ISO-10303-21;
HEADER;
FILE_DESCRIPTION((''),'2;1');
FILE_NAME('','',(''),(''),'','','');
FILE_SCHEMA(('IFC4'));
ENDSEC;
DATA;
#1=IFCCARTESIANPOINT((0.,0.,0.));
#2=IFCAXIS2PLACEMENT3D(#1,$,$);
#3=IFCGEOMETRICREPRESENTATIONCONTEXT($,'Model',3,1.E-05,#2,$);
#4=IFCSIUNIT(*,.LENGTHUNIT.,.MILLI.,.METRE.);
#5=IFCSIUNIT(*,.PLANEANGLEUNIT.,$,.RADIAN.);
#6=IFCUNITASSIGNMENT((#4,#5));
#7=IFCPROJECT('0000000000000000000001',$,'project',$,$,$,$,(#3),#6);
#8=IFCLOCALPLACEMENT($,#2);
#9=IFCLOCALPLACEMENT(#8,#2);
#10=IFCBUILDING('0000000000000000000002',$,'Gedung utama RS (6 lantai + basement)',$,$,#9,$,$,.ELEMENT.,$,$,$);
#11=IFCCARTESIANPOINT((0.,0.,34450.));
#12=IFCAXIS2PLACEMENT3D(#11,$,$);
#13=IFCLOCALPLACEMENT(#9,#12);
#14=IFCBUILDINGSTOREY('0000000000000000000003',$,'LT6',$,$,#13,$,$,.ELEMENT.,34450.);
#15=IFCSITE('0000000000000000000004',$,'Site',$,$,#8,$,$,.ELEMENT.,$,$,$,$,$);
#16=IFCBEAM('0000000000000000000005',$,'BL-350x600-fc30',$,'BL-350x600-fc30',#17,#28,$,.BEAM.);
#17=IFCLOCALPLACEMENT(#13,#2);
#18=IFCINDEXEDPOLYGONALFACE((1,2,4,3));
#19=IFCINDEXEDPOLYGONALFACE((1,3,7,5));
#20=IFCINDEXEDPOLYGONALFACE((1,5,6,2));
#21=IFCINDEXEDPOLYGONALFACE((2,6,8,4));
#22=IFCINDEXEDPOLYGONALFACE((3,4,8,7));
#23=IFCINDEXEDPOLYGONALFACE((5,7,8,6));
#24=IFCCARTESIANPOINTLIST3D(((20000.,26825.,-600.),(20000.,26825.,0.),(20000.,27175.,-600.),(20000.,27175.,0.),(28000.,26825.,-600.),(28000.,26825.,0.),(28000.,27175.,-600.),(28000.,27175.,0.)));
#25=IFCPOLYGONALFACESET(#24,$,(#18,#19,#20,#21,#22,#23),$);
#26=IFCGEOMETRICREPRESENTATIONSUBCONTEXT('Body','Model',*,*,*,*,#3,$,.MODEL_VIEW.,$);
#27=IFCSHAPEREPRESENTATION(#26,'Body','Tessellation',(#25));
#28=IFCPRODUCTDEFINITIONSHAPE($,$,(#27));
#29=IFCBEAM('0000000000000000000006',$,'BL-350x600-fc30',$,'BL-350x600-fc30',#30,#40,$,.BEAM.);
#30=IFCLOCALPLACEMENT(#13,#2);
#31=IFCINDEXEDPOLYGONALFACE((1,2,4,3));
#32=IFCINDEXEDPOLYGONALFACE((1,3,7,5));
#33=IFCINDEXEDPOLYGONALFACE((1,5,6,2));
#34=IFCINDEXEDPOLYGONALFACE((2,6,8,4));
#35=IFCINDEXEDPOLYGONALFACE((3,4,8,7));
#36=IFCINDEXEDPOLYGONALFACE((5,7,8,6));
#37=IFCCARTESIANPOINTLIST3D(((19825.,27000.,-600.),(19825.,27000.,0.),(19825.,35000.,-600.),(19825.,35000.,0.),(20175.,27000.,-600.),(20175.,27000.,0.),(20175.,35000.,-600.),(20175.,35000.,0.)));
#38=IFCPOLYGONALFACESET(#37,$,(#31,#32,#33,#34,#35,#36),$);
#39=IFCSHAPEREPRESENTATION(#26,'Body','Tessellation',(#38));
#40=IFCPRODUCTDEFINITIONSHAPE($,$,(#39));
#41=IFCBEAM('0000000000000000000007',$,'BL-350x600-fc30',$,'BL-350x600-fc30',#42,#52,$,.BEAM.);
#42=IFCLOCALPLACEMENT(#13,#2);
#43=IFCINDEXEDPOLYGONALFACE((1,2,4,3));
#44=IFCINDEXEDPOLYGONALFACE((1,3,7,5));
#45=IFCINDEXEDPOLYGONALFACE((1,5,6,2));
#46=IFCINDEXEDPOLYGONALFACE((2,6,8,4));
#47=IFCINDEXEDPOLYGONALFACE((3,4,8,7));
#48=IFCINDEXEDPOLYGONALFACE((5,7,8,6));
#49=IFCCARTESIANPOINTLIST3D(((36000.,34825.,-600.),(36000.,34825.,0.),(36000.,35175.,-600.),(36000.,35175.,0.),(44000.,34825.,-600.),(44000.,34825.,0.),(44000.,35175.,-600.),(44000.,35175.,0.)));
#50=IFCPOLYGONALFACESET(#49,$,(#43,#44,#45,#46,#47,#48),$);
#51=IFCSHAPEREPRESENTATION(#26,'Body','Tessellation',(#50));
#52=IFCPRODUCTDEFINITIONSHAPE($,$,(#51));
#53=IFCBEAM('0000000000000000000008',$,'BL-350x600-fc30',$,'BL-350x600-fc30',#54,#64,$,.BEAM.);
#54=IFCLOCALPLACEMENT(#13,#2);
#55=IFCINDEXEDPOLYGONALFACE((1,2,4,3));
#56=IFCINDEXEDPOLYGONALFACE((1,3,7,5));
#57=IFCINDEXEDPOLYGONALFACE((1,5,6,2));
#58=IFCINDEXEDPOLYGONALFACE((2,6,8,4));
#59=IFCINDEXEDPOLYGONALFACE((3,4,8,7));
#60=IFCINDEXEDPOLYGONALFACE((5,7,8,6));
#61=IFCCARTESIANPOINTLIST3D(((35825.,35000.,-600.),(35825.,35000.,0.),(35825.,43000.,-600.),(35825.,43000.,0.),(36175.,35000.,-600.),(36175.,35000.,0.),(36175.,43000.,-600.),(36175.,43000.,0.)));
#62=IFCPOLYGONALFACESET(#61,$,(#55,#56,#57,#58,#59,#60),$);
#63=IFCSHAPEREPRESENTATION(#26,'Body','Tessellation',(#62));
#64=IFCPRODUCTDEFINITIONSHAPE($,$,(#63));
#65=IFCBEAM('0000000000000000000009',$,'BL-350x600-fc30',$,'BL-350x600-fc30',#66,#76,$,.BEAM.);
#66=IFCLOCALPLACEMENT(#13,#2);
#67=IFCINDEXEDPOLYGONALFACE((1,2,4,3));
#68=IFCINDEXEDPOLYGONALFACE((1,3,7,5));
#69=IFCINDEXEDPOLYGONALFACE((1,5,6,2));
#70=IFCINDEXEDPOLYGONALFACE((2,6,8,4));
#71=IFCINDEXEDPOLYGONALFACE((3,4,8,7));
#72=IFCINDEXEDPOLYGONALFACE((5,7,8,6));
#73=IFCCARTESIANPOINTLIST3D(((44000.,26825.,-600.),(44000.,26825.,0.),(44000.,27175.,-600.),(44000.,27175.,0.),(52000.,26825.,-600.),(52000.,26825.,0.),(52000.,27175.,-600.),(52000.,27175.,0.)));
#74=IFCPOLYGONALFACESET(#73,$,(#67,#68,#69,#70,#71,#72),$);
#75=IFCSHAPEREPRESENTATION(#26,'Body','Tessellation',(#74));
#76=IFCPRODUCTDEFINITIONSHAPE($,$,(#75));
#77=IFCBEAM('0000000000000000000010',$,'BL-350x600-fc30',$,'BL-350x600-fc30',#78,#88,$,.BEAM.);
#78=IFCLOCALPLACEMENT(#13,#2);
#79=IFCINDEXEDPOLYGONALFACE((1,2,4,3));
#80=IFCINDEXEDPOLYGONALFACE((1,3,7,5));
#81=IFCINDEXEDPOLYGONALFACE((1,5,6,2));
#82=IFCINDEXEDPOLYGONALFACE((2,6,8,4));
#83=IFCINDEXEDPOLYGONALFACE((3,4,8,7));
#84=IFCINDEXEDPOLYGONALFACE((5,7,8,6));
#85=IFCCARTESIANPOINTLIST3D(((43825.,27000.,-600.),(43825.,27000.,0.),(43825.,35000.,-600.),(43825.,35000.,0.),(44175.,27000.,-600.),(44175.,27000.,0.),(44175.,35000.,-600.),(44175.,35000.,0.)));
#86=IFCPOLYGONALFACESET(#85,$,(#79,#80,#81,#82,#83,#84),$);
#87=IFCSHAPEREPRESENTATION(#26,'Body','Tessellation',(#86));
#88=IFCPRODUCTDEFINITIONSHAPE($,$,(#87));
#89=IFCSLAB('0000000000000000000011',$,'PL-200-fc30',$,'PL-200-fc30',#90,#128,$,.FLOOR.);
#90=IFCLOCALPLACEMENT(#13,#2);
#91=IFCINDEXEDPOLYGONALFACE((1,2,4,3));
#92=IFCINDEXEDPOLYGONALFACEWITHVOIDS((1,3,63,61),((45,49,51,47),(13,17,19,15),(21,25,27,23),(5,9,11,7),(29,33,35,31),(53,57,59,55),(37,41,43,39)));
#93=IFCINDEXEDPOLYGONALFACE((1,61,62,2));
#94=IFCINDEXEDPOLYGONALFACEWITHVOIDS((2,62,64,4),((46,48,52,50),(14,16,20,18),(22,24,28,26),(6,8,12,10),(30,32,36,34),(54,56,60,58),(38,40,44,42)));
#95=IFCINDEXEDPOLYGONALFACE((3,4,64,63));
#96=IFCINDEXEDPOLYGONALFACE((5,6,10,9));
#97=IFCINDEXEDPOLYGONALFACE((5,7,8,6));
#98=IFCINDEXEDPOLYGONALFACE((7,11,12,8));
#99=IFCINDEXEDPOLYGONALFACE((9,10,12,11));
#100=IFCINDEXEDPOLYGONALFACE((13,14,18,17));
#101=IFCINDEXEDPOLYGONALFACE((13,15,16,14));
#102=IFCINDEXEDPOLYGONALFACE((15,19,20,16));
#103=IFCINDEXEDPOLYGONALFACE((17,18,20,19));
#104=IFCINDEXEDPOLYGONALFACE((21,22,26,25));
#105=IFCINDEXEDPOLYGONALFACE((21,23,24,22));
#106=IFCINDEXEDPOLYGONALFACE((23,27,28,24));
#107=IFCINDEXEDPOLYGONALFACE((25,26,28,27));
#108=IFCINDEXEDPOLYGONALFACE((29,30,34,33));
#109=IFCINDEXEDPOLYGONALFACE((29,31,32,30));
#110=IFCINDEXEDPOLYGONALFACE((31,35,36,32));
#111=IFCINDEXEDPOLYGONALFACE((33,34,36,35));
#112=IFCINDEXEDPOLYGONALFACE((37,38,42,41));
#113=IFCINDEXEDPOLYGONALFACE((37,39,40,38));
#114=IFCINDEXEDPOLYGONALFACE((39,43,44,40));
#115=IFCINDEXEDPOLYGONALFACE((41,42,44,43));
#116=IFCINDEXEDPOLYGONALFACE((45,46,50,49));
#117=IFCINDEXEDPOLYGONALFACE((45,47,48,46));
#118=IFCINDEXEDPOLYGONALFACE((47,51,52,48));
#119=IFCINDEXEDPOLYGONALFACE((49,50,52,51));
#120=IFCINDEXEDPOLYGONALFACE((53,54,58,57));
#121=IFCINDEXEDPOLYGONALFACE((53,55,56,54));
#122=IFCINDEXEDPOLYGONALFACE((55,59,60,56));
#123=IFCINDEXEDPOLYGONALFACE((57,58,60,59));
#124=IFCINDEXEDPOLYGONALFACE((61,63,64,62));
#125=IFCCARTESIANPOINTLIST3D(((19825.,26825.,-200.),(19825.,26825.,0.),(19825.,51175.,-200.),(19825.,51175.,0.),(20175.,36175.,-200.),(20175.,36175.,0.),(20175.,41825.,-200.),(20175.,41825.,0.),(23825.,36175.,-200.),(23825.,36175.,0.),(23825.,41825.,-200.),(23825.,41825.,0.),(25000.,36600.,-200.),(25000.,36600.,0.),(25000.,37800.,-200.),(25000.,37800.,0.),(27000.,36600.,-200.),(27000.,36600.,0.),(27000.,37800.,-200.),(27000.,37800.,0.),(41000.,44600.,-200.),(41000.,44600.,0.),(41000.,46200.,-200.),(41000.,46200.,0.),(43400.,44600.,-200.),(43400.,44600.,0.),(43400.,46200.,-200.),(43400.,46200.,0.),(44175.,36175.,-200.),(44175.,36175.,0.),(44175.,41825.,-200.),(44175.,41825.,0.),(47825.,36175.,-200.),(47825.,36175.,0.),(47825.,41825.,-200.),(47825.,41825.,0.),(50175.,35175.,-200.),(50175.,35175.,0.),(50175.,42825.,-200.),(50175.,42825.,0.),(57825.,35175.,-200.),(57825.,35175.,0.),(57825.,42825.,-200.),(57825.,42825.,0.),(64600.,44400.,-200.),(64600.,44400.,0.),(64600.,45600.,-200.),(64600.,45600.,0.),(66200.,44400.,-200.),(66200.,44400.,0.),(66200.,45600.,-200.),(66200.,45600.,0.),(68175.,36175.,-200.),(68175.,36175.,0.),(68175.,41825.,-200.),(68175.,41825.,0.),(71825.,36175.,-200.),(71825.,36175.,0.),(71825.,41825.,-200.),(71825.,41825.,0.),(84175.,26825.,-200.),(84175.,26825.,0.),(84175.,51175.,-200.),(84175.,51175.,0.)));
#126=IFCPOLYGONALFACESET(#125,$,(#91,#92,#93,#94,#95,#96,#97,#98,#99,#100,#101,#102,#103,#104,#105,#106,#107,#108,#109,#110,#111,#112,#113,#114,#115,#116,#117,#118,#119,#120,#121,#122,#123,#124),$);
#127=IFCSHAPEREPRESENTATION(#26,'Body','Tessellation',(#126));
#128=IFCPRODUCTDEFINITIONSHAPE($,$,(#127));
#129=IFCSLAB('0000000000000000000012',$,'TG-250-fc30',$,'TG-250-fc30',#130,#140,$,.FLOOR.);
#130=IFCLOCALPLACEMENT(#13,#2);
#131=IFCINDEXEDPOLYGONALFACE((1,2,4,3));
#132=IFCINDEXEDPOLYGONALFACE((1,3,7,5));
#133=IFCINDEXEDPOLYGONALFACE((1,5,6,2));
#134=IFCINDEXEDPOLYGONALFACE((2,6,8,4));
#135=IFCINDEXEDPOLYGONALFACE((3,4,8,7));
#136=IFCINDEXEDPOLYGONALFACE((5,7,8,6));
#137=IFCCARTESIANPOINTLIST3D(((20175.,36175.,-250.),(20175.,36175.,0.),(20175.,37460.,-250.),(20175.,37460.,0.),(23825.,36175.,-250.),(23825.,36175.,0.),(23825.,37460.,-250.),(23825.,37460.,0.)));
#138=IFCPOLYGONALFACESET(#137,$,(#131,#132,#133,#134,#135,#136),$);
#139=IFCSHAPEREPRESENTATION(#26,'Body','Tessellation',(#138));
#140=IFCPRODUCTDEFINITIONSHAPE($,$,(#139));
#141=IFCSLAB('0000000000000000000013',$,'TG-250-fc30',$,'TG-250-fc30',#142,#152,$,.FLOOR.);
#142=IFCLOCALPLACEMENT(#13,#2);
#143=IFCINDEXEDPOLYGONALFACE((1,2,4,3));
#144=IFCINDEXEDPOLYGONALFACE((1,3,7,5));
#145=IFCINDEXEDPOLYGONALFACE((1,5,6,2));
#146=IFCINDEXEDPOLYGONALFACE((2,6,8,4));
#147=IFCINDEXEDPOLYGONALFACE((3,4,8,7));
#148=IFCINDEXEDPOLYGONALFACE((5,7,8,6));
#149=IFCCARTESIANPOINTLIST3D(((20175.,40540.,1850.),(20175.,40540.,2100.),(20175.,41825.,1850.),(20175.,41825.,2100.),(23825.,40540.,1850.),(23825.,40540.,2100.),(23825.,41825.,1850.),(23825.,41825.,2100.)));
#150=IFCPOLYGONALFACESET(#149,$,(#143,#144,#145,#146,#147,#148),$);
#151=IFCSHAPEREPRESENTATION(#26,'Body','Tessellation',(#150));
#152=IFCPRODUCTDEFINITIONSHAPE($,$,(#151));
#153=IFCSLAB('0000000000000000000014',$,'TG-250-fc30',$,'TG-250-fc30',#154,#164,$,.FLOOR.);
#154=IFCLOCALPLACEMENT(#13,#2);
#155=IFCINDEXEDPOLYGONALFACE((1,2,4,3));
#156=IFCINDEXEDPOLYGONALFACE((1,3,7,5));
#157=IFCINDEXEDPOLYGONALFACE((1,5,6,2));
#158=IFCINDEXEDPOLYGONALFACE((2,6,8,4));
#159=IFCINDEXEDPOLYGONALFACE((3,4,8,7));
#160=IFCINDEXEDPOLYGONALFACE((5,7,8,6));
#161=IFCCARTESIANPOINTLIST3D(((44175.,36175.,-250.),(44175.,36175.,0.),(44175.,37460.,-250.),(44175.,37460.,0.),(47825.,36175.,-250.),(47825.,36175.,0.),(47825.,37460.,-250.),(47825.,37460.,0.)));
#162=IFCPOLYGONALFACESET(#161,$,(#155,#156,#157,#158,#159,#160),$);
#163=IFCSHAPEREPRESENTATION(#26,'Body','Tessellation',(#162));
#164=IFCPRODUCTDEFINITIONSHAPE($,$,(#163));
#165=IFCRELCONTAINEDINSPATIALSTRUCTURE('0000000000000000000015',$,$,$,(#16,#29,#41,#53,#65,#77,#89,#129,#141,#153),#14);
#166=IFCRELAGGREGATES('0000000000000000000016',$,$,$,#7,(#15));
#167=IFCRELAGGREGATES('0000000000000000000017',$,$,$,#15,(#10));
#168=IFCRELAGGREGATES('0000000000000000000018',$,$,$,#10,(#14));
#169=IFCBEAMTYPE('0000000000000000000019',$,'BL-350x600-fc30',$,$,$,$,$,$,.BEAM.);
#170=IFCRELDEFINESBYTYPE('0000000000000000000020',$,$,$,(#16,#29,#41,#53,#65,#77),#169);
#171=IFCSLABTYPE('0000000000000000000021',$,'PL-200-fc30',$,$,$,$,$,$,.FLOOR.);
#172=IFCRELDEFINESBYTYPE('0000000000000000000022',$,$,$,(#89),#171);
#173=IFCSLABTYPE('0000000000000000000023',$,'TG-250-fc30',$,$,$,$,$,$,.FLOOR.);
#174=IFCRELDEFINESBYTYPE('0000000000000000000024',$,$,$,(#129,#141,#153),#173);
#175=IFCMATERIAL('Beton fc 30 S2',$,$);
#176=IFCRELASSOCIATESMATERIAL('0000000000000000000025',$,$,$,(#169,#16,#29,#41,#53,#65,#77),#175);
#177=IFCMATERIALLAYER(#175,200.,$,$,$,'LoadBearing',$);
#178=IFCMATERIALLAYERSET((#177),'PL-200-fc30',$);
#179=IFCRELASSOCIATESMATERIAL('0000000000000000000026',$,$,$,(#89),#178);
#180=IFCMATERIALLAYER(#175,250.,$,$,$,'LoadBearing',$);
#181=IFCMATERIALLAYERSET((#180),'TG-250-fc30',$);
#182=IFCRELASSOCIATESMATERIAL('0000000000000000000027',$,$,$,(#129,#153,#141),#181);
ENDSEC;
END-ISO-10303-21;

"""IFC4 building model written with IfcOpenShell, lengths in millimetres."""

from ifc_helpers import new_model, si_unit, frame, origin, origin_2d, place, context, subcontext, project, spatial, polyline, rectangle, outline, extrude, material, layer, layer_set, layer_usage, material_profile, profile_set, profile_usage, type_object, element, save


model = new_model("IFC4")

# Units and contexts
model_context = context("Model", 3, precision=1e-05, world=origin())
body_context = subcontext(model_context, "Body", "Model", "MODEL_VIEW")
ifc_project = project(units=[si_unit("LENGTHUNIT", "METRE", prefix="MILLI"), si_unit("PLANEANGLEUNIT", "RADIAN")], contexts=[model_context])

# Site, building, storey
site_placement = place(None, origin())
site = spatial("IfcSite", under=ifc_project, at=site_placement, Name="Site", CompositionType="ELEMENT")
building_placement = place(site_placement, origin())
building = spatial("IfcBuilding", under=site, at=building_placement, Name="Gedung utama RS (6 lantai + basement)", CompositionType="ELEMENT")
storey_placement = place(building_placement, frame((0.0, 0.0, 34450.0)))
storey = spatial("IfcBuildingStorey", under=building, at=storey_placement, Name="LT6", CompositionType="ELEMENT", Elevation=34450.0)

# Beams
ifc_material = material(Name="Beton fc 30 S2")
ifc_material_profile_1 = material_profile(ifc_material, rectangle(XDim=350.0, YDim=600.0, at=origin_2d()), Name="BL-350x600-fc30")
ifc_profile_set_1 = profile_set([ifc_material_profile_1], Name="BL-350x600-fc30")
ifc_profile_usage_1 = profile_usage(ifc_profile_set_1, cardinal=8)
beam_type = type_object("IfcBeamType", Name="BL-350x600-fc30", PredefinedType="BEAM", material=ifc_profile_set_1)
beam_1_placement = place(storey_placement, frame((20000.0, 27000.0, -300.0)))
element("IfcBeam", 1, at=beam_1_placement, inside=storey, type_object=beam_type, material=ifc_profile_usage_1, Name="BL-350x600-fc30", ObjectType="BL-350x600-fc30", PredefinedType="BEAM", context=body_context, shape_type="SweptSolid", body=[
    extrude(rectangle(XDim=350.0, YDim=600.0, at=origin_2d()), frame((0.0, 0.0, 0.0), z_axis=(1.0, 0.0, 0.0), x_axis=(0.0, 1.0, 0.0)), (0.0, 0.0, 1.0), 8000.0),
])
beam_2_placement = place(storey_placement, frame((20000.0, 27000.0, -300.0)))
element("IfcBeam", 2, at=beam_2_placement, inside=storey, type_object=beam_type, material=ifc_profile_usage_1, Name="BL-350x600-fc30", ObjectType="BL-350x600-fc30", PredefinedType="BEAM", context=body_context, shape_type="SweptSolid", body=[
    extrude(rectangle(XDim=350.0, YDim=600.0, at=origin_2d()), frame((0.0, 0.0, 0.0), z_axis=(0.0, 1.0, 0.0), x_axis=(-1.0, 0.0, 0.0)), (0.0, 0.0, 1.0), 8000.0),
])
beam_3_placement = place(storey_placement, frame((36000.0, 35000.0, -300.0)))
element("IfcBeam", 3, at=beam_3_placement, inside=storey, type_object=beam_type, material=ifc_profile_usage_1, Name="BL-350x600-fc30", ObjectType="BL-350x600-fc30", PredefinedType="BEAM", context=body_context, shape_type="SweptSolid", body=[
    extrude(rectangle(XDim=350.0, YDim=600.0, at=origin_2d()), frame((0.0, 0.0, 0.0), z_axis=(1.0, 0.0, 0.0), x_axis=(0.0, 1.0, 0.0)), (0.0, 0.0, 1.0), 8000.0),
])
beam_4_placement = place(storey_placement, frame((36000.0, 35000.0, -300.0)))
element("IfcBeam", 4, at=beam_4_placement, inside=storey, type_object=beam_type, material=ifc_profile_usage_1, Name="BL-350x600-fc30", ObjectType="BL-350x600-fc30", PredefinedType="BEAM", context=body_context, shape_type="SweptSolid", body=[
    extrude(rectangle(XDim=350.0, YDim=600.0, at=origin_2d()), frame((0.0, 0.0, 0.0), z_axis=(0.0, 1.0, 0.0), x_axis=(-1.0, 0.0, 0.0)), (0.0, 0.0, 1.0), 8000.0),
])
beam_5_placement = place(storey_placement, frame((44000.0, 27000.0, -300.0)))
element("IfcBeam", 5, at=beam_5_placement, inside=storey, type_object=beam_type, material=ifc_profile_usage_1, Name="BL-350x600-fc30", ObjectType="BL-350x600-fc30", PredefinedType="BEAM", context=body_context, shape_type="SweptSolid", body=[
    extrude(rectangle(XDim=350.0, YDim=600.0, at=origin_2d()), frame((0.0, 0.0, 0.0), z_axis=(1.0, 0.0, 0.0), x_axis=(0.0, 1.0, 0.0)), (0.0, 0.0, 1.0), 8000.0),
])
beam_6_placement = place(storey_placement, frame((44000.0, 27000.0, -300.0)))
element("IfcBeam", 6, at=beam_6_placement, inside=storey, type_object=beam_type, material=ifc_profile_usage_1, Name="BL-350x600-fc30", ObjectType="BL-350x600-fc30", PredefinedType="BEAM", context=body_context, shape_type="SweptSolid", body=[
    extrude(rectangle(XDim=350.0, YDim=600.0, at=origin_2d()), frame((0.0, 0.0, 0.0), z_axis=(0.0, 1.0, 0.0), x_axis=(-1.0, 0.0, 0.0)), (0.0, 0.0, 1.0), 8000.0),
])

# Slab, openings
ifc_layer_1 = layer(ifc_material, 200.0, Category="LoadBearing")
ifc_layer_set_1 = layer_set([ifc_layer_1], Name="PL-200-fc30")
ifc_layer_usage_1 = layer_usage(ifc_layer_set_1, "AXIS3", "NEGATIVE", 0.0)
slab_type_1 = type_object("IfcSlabType", Name="PL-200-fc30", PredefinedType="FLOOR")
slab_1_placement = place(storey_placement, origin())
slab_1 = element("IfcSlab", 7, at=slab_1_placement, inside=storey, type_object=slab_type_1, material=ifc_layer_usage_1, Name="PL-200-fc30", ObjectType="PL-200-fc30", PredefinedType="FLOOR", context=body_context, shape_type="SweptSolid", body=[
    extrude(outline(polyline([(84175.0, 51175.0), (19825.0, 51175.0), (19825.0, 26825.0), (84175.0, 26825.0), (84175.0, 51175.0)]), holes=[polyline([(23825.0, 36175.0), (23825.0, 41825.0), (20175.0, 41825.0), (20175.0, 36175.0), (23825.0, 36175.0)]), polyline([(47825.0, 36175.0), (47825.0, 41825.0), (44175.0, 41825.0), (44175.0, 36175.0), (47825.0, 36175.0)]), polyline([(71825.0, 36175.0), (71825.0, 41825.0), (68175.0, 41825.0), (68175.0, 36175.0), (71825.0, 36175.0)])]), frame((0.0, 0.0, -200.0)), (0.0, 0.0, 1.0), 200.0),
])
opening_1_placement = place(slab_1_placement, frame((0.0, 0.0, -21500.0)))
element("IfcOpeningElement", 8, at=opening_1_placement, cuts=slab_1, PredefinedType="OPENING", context=body_context, shape_type="SweptSolid", body=[
    extrude(outline(polyline([(27000.0, 36600.0), (27000.0, 37800.0), (25000.0, 37800.0), (25000.0, 36600.0), (27000.0, 36600.0)])), origin(), (0.0, 0.0, 1.0), 25800.0),
])
opening_2_placement = place(slab_1_placement, frame((0.0, 0.0, -21500.0)))
element("IfcOpeningElement", 9, at=opening_2_placement, cuts=slab_1, PredefinedType="OPENING", context=body_context, shape_type="SweptSolid", body=[
    extrude(outline(polyline([(43400.0, 44600.0), (43400.0, 46200.0), (41000.0, 46200.0), (41000.0, 44600.0), (43400.0, 44600.0)])), origin(), (0.0, 0.0, 1.0), 25800.0),
])
opening_3_placement = place(slab_1_placement, frame((0.0, 0.0, -21500.0)))
element("IfcOpeningElement", 10, at=opening_3_placement, cuts=slab_1, PredefinedType="OPENING", context=body_context, shape_type="SweptSolid", body=[
    extrude(outline(polyline([(66200.0, 44400.0), (66200.0, 45600.0), (64600.0, 45600.0), (64600.0, 44400.0), (66200.0, 44400.0)])), origin(), (0.0, 0.0, 1.0), 25800.0),
])
opening_4_placement = place(slab_1_placement, frame((0.0, 0.0, -21500.0)))
element("IfcOpeningElement", 11, at=opening_4_placement, cuts=slab_1, PredefinedType="OPENING", context=body_context, shape_type="SweptSolid", body=[
    extrude(outline(polyline([(57825.0, 35175.0), (57825.0, 42825.0), (50175.0, 42825.0), (50175.0, 35175.0), (57825.0, 35175.0)])), origin(), (0.0, 0.0, 1.0), 21600.0),
])

# Slabs
ifc_layer_2 = layer(ifc_material, 250.0, Category="LoadBearing")
ifc_layer_set_2 = layer_set([ifc_layer_2], Name="TG-250-fc30")
ifc_layer_usage_2 = layer_usage(ifc_layer_set_2, "AXIS3", "NEGATIVE", 0.0)
slab_type_2 = type_object("IfcSlabType", Name="TG-250-fc30", PredefinedType="FLOOR")
slab_2_placement = place(storey_placement, origin())
element("IfcSlab", 12, at=slab_2_placement, inside=storey, type_object=slab_type_2, material=ifc_layer_usage_2, Name="TG-250-fc30", ObjectType="TG-250-fc30", PredefinedType="FLOOR", context=body_context, shape_type="SweptSolid", body=[
    extrude(outline(polyline([(23825.0, 36175.0), (23825.0, 37460.0), (20175.0, 37460.0), (20175.0, 36175.0), (23825.0, 36175.0)])), frame((0.0, 0.0, -250.0)), (0.0, 0.0, 1.0), 250.0),
])
ifc_layer_usage_3 = layer_usage(ifc_layer_set_2, "AXIS3", "NEGATIVE", 2100.0)
slab_3_placement = place(storey_placement, origin())
element("IfcSlab", 13, at=slab_3_placement, inside=storey, type_object=slab_type_2, material=ifc_layer_usage_3, Name="TG-250-fc30", ObjectType="TG-250-fc30", PredefinedType="FLOOR", context=body_context, shape_type="SweptSolid", body=[
    extrude(outline(polyline([(23825.0, 40540.0), (23825.0, 41825.0), (20175.0, 41825.0), (20175.0, 40540.0), (23825.0, 40540.0)])), frame((0.0, 0.0, 1850.0)), (0.0, 0.0, 1.0), 250.0),
])
slab_4_placement = place(storey_placement, origin())
element("IfcSlab", 14, at=slab_4_placement, inside=storey, type_object=slab_type_2, material=ifc_layer_usage_2, Name="TG-250-fc30", ObjectType="TG-250-fc30", PredefinedType="FLOOR", context=body_context, shape_type="SweptSolid", body=[
    extrude(outline(polyline([(47825.0, 36175.0), (47825.0, 37460.0), (44175.0, 37460.0), (44175.0, 36175.0), (47825.0, 36175.0)])), frame((0.0, 0.0, -250.0)), (0.0, 0.0, 1.0), 250.0),
])

save(model, "model.ifc")
